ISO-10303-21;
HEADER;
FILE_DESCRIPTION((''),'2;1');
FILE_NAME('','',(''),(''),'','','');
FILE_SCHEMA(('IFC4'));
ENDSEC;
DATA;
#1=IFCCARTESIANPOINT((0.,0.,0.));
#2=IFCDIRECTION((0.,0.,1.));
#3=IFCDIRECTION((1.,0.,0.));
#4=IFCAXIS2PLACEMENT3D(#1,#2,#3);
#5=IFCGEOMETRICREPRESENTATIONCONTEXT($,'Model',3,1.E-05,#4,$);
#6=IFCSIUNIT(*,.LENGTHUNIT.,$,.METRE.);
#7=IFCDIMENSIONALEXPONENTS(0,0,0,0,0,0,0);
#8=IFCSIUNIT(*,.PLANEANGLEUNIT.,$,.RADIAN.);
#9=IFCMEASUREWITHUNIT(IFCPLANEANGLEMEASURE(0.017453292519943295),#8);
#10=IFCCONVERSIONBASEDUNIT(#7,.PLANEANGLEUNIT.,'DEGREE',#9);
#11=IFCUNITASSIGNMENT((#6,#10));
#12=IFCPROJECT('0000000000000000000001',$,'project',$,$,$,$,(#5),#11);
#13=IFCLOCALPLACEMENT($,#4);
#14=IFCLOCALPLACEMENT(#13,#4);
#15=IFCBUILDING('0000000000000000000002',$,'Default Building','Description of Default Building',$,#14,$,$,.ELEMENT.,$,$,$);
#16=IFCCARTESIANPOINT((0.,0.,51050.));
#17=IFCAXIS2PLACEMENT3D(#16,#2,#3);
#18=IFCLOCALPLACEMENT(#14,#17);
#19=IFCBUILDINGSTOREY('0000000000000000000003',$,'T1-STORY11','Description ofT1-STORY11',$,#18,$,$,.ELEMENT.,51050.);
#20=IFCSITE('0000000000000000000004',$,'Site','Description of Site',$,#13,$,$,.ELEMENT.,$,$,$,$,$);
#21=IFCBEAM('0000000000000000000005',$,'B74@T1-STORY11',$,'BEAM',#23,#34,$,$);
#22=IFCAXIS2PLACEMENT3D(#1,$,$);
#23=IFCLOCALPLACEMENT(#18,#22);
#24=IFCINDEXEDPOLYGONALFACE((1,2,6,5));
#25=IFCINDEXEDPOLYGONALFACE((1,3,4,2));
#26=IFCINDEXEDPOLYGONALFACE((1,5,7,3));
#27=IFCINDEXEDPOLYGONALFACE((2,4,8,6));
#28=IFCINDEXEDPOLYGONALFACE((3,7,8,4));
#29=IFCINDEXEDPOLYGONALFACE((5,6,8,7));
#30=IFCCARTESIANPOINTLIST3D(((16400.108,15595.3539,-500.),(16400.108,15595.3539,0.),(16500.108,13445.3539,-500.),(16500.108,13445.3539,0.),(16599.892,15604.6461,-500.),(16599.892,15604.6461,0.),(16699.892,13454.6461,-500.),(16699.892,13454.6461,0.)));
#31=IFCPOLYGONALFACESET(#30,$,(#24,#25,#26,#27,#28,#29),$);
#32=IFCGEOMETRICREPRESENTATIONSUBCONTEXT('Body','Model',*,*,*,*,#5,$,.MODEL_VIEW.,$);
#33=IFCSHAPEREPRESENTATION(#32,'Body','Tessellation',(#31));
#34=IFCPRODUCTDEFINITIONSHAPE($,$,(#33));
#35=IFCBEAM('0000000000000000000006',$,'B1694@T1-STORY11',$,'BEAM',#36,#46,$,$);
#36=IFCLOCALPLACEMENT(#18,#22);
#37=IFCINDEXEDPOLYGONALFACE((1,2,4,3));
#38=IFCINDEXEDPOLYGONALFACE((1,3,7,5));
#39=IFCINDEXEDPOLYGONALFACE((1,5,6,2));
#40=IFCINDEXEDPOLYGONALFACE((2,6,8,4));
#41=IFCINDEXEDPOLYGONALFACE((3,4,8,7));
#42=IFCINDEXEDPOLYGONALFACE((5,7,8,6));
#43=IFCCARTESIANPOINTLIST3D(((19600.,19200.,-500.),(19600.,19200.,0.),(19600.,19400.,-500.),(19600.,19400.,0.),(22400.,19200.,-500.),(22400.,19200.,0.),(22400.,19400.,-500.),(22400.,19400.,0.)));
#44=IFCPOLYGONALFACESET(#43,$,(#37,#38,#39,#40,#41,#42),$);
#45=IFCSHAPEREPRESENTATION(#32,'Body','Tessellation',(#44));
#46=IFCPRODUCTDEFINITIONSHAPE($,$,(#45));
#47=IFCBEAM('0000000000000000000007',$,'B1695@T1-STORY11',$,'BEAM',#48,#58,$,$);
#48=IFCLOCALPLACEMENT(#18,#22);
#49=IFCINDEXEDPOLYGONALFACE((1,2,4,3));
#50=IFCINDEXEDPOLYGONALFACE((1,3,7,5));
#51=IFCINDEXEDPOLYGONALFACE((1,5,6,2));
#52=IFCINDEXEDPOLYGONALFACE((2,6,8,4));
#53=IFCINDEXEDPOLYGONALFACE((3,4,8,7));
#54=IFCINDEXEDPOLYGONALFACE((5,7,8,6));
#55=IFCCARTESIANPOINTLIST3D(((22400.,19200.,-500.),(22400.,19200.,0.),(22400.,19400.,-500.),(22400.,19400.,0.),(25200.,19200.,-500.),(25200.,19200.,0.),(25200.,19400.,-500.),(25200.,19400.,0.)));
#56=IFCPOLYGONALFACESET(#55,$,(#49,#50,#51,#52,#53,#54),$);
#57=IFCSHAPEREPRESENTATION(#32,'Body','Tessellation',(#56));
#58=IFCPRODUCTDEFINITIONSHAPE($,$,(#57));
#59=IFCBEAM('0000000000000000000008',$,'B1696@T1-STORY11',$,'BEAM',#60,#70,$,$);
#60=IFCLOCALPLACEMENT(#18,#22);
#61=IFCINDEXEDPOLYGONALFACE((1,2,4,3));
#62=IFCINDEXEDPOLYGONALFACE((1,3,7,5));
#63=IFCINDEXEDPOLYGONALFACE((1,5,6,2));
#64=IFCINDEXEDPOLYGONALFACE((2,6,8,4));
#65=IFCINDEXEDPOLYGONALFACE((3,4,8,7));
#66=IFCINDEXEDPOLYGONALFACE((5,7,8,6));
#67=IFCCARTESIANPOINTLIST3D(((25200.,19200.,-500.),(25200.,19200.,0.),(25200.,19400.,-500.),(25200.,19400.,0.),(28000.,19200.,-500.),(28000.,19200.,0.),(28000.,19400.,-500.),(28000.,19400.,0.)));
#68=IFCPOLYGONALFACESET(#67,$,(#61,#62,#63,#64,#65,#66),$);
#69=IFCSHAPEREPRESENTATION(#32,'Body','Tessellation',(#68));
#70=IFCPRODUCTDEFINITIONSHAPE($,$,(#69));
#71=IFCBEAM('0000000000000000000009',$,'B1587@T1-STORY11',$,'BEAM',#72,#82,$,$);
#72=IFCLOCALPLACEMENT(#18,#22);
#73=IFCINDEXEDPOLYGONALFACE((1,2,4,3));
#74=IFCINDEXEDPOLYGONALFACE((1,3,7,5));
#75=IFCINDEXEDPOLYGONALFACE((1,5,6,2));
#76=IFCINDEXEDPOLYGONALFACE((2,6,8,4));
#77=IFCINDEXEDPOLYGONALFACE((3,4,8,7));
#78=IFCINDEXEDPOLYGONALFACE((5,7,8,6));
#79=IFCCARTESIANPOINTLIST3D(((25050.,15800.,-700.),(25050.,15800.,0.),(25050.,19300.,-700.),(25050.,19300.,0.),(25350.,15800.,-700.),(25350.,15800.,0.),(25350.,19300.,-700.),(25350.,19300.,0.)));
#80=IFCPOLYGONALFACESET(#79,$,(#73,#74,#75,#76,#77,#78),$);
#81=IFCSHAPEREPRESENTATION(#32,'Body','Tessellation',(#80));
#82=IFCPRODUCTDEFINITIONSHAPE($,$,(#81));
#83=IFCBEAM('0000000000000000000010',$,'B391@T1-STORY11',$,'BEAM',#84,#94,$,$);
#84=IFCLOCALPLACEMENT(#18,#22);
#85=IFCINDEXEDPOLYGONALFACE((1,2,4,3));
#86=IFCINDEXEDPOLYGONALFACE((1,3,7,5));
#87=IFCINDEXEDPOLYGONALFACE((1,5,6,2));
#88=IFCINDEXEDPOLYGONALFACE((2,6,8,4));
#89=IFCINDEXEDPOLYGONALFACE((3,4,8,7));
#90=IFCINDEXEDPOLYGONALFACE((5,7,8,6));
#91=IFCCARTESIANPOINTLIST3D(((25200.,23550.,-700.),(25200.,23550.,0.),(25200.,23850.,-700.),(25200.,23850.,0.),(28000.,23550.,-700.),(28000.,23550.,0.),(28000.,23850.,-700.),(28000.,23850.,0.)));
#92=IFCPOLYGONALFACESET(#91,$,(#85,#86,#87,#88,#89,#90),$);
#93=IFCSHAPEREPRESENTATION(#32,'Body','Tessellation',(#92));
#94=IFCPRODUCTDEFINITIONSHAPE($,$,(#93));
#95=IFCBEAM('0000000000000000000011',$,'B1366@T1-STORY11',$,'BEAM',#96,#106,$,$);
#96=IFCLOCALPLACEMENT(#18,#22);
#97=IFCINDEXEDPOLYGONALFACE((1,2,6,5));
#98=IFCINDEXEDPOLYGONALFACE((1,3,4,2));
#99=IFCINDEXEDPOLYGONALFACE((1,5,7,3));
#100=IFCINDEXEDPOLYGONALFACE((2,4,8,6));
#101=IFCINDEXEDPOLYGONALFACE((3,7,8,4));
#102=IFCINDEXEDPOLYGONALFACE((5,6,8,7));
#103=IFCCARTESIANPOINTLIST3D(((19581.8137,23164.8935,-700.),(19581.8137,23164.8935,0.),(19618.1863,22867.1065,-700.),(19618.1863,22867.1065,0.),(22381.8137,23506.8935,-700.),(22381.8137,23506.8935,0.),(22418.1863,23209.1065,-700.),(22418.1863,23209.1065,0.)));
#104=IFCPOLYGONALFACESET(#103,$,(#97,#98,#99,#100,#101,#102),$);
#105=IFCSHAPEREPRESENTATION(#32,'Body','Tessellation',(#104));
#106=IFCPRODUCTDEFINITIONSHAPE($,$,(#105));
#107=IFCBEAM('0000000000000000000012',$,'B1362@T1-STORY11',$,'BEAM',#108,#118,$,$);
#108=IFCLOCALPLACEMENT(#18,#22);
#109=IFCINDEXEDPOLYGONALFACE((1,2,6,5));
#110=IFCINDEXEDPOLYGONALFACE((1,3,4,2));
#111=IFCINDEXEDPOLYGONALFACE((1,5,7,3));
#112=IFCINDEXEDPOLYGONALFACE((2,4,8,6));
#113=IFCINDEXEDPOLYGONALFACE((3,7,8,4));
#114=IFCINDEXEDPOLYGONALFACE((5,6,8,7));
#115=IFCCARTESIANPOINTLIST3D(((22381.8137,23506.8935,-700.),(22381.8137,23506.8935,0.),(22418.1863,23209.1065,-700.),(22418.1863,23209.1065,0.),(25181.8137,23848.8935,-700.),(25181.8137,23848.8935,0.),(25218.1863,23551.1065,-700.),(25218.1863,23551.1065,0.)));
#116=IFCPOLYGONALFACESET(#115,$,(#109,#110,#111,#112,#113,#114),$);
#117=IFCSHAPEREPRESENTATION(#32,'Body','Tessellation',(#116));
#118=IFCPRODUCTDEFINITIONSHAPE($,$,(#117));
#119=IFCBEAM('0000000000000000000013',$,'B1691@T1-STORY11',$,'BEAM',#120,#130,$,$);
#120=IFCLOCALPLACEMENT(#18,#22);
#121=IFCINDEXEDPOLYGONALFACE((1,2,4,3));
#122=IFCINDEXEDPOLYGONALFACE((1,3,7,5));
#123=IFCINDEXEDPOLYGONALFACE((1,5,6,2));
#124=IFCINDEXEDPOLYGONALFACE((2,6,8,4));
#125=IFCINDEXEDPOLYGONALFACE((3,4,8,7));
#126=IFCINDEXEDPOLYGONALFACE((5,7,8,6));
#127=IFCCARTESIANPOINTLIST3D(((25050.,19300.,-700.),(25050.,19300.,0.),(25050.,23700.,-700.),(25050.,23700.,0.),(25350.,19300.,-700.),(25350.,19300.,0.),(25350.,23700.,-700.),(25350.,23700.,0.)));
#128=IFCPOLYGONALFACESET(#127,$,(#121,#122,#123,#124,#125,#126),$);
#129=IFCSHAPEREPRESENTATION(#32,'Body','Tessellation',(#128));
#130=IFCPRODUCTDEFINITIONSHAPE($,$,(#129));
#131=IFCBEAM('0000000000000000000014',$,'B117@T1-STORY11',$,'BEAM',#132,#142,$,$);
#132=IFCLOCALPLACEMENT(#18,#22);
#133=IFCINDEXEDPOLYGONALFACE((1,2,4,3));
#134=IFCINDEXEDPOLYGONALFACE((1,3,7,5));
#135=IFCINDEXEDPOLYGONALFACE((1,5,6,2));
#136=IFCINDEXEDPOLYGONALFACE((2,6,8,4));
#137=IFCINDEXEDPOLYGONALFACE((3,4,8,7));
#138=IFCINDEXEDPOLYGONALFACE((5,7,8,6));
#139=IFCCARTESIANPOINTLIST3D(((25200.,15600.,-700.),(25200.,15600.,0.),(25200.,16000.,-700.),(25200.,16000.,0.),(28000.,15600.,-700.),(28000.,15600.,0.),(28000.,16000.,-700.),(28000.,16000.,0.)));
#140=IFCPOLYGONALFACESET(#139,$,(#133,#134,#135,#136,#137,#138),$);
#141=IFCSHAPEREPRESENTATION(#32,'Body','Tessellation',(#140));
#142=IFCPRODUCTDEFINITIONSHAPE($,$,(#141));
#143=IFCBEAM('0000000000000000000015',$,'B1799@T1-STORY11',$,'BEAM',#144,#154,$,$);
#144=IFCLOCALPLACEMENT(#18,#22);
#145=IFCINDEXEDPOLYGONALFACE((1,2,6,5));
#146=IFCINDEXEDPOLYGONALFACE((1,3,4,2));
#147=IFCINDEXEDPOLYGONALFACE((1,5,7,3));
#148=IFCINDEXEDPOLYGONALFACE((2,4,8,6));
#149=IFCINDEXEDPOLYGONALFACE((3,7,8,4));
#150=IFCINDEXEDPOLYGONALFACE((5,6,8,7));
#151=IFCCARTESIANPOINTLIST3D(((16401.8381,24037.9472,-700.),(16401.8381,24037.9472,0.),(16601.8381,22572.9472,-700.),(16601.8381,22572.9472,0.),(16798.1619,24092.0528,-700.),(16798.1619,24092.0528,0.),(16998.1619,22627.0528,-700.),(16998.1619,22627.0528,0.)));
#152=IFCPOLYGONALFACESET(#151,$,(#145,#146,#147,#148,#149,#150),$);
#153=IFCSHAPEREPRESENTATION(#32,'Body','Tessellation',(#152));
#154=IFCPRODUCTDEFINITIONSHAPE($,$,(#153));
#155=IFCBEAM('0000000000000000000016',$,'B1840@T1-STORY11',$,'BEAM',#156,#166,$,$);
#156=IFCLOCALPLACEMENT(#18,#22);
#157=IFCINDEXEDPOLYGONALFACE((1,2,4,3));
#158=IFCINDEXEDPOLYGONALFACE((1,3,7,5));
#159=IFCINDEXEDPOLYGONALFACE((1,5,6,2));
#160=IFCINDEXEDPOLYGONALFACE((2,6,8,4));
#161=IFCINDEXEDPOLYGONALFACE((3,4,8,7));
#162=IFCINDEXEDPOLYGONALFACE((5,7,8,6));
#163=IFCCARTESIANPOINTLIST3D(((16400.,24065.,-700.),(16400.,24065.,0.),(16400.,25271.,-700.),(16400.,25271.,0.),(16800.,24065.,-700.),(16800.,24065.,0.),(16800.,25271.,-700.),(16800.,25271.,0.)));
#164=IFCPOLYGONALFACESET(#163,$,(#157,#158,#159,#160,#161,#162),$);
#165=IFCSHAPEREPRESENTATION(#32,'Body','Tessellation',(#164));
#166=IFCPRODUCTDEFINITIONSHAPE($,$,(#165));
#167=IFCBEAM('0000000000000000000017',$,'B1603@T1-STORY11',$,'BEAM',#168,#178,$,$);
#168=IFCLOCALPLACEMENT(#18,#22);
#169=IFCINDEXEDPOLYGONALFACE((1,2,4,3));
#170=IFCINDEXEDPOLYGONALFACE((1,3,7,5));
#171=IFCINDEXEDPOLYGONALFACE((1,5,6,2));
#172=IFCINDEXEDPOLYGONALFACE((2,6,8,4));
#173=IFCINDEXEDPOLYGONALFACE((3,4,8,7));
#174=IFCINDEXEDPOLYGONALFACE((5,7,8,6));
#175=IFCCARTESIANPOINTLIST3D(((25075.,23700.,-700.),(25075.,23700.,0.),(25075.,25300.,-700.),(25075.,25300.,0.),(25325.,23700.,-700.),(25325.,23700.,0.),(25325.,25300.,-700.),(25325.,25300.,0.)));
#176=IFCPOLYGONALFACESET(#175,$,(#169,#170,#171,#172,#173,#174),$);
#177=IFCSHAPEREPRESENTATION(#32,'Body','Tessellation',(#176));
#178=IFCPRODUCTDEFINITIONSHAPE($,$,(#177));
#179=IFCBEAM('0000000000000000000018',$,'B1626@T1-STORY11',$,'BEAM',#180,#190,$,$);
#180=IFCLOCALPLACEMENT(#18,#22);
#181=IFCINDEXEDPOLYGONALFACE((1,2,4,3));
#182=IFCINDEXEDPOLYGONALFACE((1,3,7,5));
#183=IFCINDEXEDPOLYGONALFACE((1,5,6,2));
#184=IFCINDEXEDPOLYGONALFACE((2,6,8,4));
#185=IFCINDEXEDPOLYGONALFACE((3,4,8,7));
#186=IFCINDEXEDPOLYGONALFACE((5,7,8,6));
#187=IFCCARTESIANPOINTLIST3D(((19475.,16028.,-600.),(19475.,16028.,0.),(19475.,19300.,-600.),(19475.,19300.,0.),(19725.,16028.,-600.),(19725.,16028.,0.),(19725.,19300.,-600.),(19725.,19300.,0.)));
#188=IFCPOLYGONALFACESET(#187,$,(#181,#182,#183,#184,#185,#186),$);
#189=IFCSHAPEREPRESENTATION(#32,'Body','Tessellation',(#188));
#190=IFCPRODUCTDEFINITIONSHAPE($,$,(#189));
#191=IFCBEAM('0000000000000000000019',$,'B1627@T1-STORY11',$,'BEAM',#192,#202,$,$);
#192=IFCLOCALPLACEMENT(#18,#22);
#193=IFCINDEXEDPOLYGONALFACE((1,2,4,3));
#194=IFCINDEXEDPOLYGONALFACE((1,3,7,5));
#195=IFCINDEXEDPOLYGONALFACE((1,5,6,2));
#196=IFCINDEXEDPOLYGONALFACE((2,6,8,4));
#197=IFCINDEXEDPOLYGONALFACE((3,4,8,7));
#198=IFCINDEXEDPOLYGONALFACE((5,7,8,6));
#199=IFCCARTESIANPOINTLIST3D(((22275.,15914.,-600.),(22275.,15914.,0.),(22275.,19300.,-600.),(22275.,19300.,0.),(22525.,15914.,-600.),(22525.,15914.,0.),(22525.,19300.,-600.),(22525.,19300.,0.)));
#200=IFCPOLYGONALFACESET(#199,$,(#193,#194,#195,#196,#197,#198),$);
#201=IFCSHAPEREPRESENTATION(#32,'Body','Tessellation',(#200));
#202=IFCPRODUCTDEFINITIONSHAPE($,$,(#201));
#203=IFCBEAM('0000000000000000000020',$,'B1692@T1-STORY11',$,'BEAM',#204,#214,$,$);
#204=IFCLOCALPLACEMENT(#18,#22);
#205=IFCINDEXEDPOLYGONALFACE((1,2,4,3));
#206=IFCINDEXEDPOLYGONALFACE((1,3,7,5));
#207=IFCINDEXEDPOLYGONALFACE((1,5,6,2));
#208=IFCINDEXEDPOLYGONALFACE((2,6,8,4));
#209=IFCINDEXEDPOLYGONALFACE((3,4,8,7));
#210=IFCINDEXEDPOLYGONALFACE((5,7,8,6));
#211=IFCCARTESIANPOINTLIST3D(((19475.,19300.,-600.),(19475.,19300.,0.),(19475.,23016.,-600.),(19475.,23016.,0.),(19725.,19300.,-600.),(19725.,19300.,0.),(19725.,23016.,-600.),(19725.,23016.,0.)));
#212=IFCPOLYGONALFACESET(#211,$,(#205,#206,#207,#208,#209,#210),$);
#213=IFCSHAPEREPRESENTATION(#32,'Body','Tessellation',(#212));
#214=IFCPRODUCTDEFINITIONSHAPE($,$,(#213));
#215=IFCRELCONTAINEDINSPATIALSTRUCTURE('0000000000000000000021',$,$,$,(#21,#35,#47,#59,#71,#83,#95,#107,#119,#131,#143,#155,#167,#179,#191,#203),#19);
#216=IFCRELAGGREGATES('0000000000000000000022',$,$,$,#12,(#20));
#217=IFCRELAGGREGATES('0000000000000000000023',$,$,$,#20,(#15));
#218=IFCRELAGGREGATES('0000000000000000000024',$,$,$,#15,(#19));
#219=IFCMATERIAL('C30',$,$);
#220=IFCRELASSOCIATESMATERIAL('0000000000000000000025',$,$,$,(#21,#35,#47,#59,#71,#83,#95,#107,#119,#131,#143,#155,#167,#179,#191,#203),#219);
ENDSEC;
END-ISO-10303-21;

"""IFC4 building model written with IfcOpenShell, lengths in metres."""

from ifc_helpers import new_model, entity, si_unit, converted_unit, frame, origin_with_axes, place, context, subcontext, project, spatial, rectangle, extrude, material, element, save


model = new_model("IFC4")

# Units and contexts
model_context = context("Model", 3, precision=1e-05, world=origin_with_axes())
body_context = subcontext(model_context, "Body", "Model", "MODEL_VIEW")
ifc_project = project(units=[si_unit("LENGTHUNIT", "METRE"), converted_unit("PLANEANGLEUNIT", "DEGREE", entity("IfcPlaneAngleMeasure", 0.017453292519943295), si_unit("PLANEANGLEUNIT", "RADIAN"), dimensions=[0, 0, 0, 0, 0, 0, 0])], contexts=[model_context])

# Site, building, storey
site_placement = place(None, origin_with_axes())
site = spatial("IfcSite", under=ifc_project, at=site_placement, Name="Site", Description="Description of Site", CompositionType="ELEMENT")
building_placement = place(site_placement, origin_with_axes())
building = spatial("IfcBuilding", under=site, at=building_placement, Name="Default Building", Description="Description of Default Building", CompositionType="ELEMENT")
storey_placement = place(building_placement, frame((0.0, 0.0, 51050.0), z_axis=(0.0, 0.0, 1.0), x_axis=(1.0, 0.0, 0.0)))
storey = spatial("IfcBuildingStorey", under=building, at=storey_placement, Name="T1-STORY11", Description="Description ofT1-STORY11", CompositionType="ELEMENT", Elevation=51050.0)

# Beams
ifc_material_1 = material(Name="C30")
beam_1_placement = place(storey_placement, frame((16600.0, 13450.0, -250.0), z_axis=(-0.046461, 0.99892, 0.0), x_axis=(-0.99892, -0.046461, 0.0)))
element("IfcBeam", 1, at=beam_1_placement, inside=storey, material=ifc_material_1, Name="B74@T1-STORY11", ObjectType="BEAM", context=body_context, shape_type="SweptSolid", body=[
    extrude(rectangle(XDim=200.0, YDim=500.0), origin_with_axes(), (0.0, 0.0, 1.0), 2152.3243),
])
for number, where, z_axis, x_axis, name in (
    (2, (19600.0, 19300.0, -250.0), (1.0, 0.0, 0.0), (0.0, 1.0, 0.0), "B1694@T1-STORY11"),
    (3, (22400.0, 19300.0, -250.0), (1.0, 0.0, 0.0), (0.0, 1.0, 0.0), "B1695@T1-STORY11"),
    (4, (25200.0, 19300.0, -250.0), (1.0, 0.0, 0.0), (0.0, 1.0, 0.0), "B1696@T1-STORY11"),
):
    element("IfcBeam", number, at=place(storey_placement, frame(where, z_axis=z_axis, x_axis=x_axis)), inside=storey, material=ifc_material_1, Name=name, ObjectType="BEAM", context=body_context, shape_type="SweptSolid", body=[
        extrude(rectangle(XDim=200.0, YDim=500.0), origin_with_axes(), (0.0, 0.0, 1.0), 2800.0),
    ])
beam_2_placement = place(storey_placement, frame((25200.0, 15800.0, -350.0), z_axis=(0.0, 1.0, 0.0), x_axis=(-1.0, 0.0, 0.0)))
element("IfcBeam", 5, at=beam_2_placement, inside=storey, material=ifc_material_1, Name="B1587@T1-STORY11", ObjectType="BEAM", context=body_context, shape_type="SweptSolid", body=[
    extrude(rectangle(XDim=300.0, YDim=700.0), origin_with_axes(), (0.0, 0.0, 1.0), 3500.0),
])
beam_3_placement = place(storey_placement, frame((25200.0, 23700.0, -350.0), z_axis=(1.0, 0.0, 0.0), x_axis=(0.0, 1.0, 0.0)))
element("IfcBeam", 6, at=beam_3_placement, inside=storey, material=ifc_material_1, Name="B391@T1-STORY11", ObjectType="BEAM", context=body_context, shape_type="SweptSolid", body=[
    extrude(rectangle(XDim=300.0, YDim=700.0), origin_with_axes(), (0.0, 0.0, 1.0), 2800.0),
])
for number, where, z_axis, x_axis, name in (
    (7, (19600.0, 23016.0, -350.0), (0.992623, 0.121242, 0.0), (-0.121242, 0.992623, 0.0), "B1366@T1-STORY11"),
    (8, (22400.0, 23358.0, -350.0), (0.992623, 0.121242, 0.0), (-0.121242, 0.992623, 0.0), "B1362@T1-STORY11"),
):
    element("IfcBeam", number, at=place(storey_placement, frame(where, z_axis=z_axis, x_axis=x_axis)), inside=storey, material=ifc_material_1, Name=name, ObjectType="BEAM", context=body_context, shape_type="SweptSolid", body=[
        extrude(rectangle(XDim=300.0, YDim=700.0), origin_with_axes(), (0.0, 0.0, 1.0), 2820.8091),
    ])
beam_4_placement = place(storey_placement, frame((25200.0, 19300.0, -350.0), z_axis=(0.0, 1.0, 0.0), x_axis=(-1.0, 0.0, 0.0)))
element("IfcBeam", 9, at=beam_4_placement, inside=storey, material=ifc_material_1, Name="B1691@T1-STORY11", ObjectType="BEAM", context=body_context, shape_type="SweptSolid", body=[
    extrude(rectangle(XDim=300.0, YDim=700.0), origin_with_axes(), (0.0, 0.0, 1.0), 4400.0),
])
beam_5_placement = place(storey_placement, frame((25200.0, 15800.0, -350.0), z_axis=(1.0, 0.0, 0.0), x_axis=(0.0, 1.0, 0.0)))
element("IfcBeam", 10, at=beam_5_placement, inside=storey, material=ifc_material_1, Name="B117@T1-STORY11", ObjectType="BEAM", context=body_context, shape_type="SweptSolid", body=[
    extrude(rectangle(XDim=400.0, YDim=700.0), origin_with_axes(), (0.0, 0.0, 1.0), 2800.0),
])
beam_6_placement = place(storey_placement, frame((16800.0, 22600.0, -350.0), z_axis=(-0.135264, 0.99081, 0.0), x_axis=(-0.99081, -0.135264, 0.0)))
element("IfcBeam", 11, at=beam_6_placement, inside=storey, material=ifc_material_1, Name="B1799@T1-STORY11", ObjectType="BEAM", context=body_context, shape_type="SweptSolid", body=[
    extrude(rectangle(XDim=400.0, YDim=700.0), origin_with_axes(), (0.0, 0.0, 1.0), 1478.5889),
])
beam_7_placement = place(storey_placement, frame((16600.0, 24065.0, -350.0), z_axis=(0.0, 1.0, 0.0), x_axis=(-1.0, 0.0, 0.0)))
element("IfcBeam", 12, at=beam_7_placement, inside=storey, material=ifc_material_1, Name="B1840@T1-STORY11", ObjectType="BEAM", context=body_context, shape_type="SweptSolid", body=[
    extrude(rectangle(XDim=400.0, YDim=700.0), origin_with_axes(), (0.0, 0.0, 1.0), 1206.0),
])
beam_8_placement = place(storey_placement, frame((25200.0, 23700.0, -350.0), z_axis=(0.0, 1.0, 0.0), x_axis=(-1.0, 0.0, 0.0)))
element("IfcBeam", 13, at=beam_8_placement, inside=storey, material=ifc_material_1, Name="B1603@T1-STORY11", ObjectType="BEAM", context=body_context, shape_type="SweptSolid", body=[
    extrude(rectangle(XDim=250.0, YDim=700.0), origin_with_axes(), (0.0, 0.0, 1.0), 1600.0),
])
beam_9_placement = place(storey_placement, frame((19600.0, 16028.0, -300.0), z_axis=(0.0, 1.0, 0.0), x_axis=(-1.0, 0.0, 0.0)))
element("IfcBeam", 14, at=beam_9_placement, inside=storey, material=ifc_material_1, Name="B1626@T1-STORY11", ObjectType="BEAM", context=body_context, shape_type="SweptSolid", body=[
    extrude(rectangle(XDim=250.0, YDim=600.0), origin_with_axes(), (0.0, 0.0, 1.0), 3272.0),
])
beam_10_placement = place(storey_placement, frame((22400.0, 15914.0, -300.0), z_axis=(0.0, 1.0, 0.0), x_axis=(-1.0, 0.0, 0.0)))
element("IfcBeam", 15, at=beam_10_placement, inside=storey, material=ifc_material_1, Name="B1627@T1-STORY11", ObjectType="BEAM", context=body_context, shape_type="SweptSolid", body=[
    extrude(rectangle(XDim=250.0, YDim=600.0), origin_with_axes(), (0.0, 0.0, 1.0), 3386.0),
])
beam_11_placement = place(storey_placement, frame((19600.0, 19300.0, -300.0), z_axis=(0.0, 1.0, 0.0), x_axis=(-1.0, 0.0, 0.0)))
element("IfcBeam", 16, at=beam_11_placement, inside=storey, material=ifc_material_1, Name="B1692@T1-STORY11", ObjectType="BEAM", context=body_context, shape_type="SweptSolid", body=[
    extrude(rectangle(XDim=250.0, YDim=600.0), origin_with_axes(), (0.0, 0.0, 1.0), 3716.0),
])

save(model, "model.ifc")
